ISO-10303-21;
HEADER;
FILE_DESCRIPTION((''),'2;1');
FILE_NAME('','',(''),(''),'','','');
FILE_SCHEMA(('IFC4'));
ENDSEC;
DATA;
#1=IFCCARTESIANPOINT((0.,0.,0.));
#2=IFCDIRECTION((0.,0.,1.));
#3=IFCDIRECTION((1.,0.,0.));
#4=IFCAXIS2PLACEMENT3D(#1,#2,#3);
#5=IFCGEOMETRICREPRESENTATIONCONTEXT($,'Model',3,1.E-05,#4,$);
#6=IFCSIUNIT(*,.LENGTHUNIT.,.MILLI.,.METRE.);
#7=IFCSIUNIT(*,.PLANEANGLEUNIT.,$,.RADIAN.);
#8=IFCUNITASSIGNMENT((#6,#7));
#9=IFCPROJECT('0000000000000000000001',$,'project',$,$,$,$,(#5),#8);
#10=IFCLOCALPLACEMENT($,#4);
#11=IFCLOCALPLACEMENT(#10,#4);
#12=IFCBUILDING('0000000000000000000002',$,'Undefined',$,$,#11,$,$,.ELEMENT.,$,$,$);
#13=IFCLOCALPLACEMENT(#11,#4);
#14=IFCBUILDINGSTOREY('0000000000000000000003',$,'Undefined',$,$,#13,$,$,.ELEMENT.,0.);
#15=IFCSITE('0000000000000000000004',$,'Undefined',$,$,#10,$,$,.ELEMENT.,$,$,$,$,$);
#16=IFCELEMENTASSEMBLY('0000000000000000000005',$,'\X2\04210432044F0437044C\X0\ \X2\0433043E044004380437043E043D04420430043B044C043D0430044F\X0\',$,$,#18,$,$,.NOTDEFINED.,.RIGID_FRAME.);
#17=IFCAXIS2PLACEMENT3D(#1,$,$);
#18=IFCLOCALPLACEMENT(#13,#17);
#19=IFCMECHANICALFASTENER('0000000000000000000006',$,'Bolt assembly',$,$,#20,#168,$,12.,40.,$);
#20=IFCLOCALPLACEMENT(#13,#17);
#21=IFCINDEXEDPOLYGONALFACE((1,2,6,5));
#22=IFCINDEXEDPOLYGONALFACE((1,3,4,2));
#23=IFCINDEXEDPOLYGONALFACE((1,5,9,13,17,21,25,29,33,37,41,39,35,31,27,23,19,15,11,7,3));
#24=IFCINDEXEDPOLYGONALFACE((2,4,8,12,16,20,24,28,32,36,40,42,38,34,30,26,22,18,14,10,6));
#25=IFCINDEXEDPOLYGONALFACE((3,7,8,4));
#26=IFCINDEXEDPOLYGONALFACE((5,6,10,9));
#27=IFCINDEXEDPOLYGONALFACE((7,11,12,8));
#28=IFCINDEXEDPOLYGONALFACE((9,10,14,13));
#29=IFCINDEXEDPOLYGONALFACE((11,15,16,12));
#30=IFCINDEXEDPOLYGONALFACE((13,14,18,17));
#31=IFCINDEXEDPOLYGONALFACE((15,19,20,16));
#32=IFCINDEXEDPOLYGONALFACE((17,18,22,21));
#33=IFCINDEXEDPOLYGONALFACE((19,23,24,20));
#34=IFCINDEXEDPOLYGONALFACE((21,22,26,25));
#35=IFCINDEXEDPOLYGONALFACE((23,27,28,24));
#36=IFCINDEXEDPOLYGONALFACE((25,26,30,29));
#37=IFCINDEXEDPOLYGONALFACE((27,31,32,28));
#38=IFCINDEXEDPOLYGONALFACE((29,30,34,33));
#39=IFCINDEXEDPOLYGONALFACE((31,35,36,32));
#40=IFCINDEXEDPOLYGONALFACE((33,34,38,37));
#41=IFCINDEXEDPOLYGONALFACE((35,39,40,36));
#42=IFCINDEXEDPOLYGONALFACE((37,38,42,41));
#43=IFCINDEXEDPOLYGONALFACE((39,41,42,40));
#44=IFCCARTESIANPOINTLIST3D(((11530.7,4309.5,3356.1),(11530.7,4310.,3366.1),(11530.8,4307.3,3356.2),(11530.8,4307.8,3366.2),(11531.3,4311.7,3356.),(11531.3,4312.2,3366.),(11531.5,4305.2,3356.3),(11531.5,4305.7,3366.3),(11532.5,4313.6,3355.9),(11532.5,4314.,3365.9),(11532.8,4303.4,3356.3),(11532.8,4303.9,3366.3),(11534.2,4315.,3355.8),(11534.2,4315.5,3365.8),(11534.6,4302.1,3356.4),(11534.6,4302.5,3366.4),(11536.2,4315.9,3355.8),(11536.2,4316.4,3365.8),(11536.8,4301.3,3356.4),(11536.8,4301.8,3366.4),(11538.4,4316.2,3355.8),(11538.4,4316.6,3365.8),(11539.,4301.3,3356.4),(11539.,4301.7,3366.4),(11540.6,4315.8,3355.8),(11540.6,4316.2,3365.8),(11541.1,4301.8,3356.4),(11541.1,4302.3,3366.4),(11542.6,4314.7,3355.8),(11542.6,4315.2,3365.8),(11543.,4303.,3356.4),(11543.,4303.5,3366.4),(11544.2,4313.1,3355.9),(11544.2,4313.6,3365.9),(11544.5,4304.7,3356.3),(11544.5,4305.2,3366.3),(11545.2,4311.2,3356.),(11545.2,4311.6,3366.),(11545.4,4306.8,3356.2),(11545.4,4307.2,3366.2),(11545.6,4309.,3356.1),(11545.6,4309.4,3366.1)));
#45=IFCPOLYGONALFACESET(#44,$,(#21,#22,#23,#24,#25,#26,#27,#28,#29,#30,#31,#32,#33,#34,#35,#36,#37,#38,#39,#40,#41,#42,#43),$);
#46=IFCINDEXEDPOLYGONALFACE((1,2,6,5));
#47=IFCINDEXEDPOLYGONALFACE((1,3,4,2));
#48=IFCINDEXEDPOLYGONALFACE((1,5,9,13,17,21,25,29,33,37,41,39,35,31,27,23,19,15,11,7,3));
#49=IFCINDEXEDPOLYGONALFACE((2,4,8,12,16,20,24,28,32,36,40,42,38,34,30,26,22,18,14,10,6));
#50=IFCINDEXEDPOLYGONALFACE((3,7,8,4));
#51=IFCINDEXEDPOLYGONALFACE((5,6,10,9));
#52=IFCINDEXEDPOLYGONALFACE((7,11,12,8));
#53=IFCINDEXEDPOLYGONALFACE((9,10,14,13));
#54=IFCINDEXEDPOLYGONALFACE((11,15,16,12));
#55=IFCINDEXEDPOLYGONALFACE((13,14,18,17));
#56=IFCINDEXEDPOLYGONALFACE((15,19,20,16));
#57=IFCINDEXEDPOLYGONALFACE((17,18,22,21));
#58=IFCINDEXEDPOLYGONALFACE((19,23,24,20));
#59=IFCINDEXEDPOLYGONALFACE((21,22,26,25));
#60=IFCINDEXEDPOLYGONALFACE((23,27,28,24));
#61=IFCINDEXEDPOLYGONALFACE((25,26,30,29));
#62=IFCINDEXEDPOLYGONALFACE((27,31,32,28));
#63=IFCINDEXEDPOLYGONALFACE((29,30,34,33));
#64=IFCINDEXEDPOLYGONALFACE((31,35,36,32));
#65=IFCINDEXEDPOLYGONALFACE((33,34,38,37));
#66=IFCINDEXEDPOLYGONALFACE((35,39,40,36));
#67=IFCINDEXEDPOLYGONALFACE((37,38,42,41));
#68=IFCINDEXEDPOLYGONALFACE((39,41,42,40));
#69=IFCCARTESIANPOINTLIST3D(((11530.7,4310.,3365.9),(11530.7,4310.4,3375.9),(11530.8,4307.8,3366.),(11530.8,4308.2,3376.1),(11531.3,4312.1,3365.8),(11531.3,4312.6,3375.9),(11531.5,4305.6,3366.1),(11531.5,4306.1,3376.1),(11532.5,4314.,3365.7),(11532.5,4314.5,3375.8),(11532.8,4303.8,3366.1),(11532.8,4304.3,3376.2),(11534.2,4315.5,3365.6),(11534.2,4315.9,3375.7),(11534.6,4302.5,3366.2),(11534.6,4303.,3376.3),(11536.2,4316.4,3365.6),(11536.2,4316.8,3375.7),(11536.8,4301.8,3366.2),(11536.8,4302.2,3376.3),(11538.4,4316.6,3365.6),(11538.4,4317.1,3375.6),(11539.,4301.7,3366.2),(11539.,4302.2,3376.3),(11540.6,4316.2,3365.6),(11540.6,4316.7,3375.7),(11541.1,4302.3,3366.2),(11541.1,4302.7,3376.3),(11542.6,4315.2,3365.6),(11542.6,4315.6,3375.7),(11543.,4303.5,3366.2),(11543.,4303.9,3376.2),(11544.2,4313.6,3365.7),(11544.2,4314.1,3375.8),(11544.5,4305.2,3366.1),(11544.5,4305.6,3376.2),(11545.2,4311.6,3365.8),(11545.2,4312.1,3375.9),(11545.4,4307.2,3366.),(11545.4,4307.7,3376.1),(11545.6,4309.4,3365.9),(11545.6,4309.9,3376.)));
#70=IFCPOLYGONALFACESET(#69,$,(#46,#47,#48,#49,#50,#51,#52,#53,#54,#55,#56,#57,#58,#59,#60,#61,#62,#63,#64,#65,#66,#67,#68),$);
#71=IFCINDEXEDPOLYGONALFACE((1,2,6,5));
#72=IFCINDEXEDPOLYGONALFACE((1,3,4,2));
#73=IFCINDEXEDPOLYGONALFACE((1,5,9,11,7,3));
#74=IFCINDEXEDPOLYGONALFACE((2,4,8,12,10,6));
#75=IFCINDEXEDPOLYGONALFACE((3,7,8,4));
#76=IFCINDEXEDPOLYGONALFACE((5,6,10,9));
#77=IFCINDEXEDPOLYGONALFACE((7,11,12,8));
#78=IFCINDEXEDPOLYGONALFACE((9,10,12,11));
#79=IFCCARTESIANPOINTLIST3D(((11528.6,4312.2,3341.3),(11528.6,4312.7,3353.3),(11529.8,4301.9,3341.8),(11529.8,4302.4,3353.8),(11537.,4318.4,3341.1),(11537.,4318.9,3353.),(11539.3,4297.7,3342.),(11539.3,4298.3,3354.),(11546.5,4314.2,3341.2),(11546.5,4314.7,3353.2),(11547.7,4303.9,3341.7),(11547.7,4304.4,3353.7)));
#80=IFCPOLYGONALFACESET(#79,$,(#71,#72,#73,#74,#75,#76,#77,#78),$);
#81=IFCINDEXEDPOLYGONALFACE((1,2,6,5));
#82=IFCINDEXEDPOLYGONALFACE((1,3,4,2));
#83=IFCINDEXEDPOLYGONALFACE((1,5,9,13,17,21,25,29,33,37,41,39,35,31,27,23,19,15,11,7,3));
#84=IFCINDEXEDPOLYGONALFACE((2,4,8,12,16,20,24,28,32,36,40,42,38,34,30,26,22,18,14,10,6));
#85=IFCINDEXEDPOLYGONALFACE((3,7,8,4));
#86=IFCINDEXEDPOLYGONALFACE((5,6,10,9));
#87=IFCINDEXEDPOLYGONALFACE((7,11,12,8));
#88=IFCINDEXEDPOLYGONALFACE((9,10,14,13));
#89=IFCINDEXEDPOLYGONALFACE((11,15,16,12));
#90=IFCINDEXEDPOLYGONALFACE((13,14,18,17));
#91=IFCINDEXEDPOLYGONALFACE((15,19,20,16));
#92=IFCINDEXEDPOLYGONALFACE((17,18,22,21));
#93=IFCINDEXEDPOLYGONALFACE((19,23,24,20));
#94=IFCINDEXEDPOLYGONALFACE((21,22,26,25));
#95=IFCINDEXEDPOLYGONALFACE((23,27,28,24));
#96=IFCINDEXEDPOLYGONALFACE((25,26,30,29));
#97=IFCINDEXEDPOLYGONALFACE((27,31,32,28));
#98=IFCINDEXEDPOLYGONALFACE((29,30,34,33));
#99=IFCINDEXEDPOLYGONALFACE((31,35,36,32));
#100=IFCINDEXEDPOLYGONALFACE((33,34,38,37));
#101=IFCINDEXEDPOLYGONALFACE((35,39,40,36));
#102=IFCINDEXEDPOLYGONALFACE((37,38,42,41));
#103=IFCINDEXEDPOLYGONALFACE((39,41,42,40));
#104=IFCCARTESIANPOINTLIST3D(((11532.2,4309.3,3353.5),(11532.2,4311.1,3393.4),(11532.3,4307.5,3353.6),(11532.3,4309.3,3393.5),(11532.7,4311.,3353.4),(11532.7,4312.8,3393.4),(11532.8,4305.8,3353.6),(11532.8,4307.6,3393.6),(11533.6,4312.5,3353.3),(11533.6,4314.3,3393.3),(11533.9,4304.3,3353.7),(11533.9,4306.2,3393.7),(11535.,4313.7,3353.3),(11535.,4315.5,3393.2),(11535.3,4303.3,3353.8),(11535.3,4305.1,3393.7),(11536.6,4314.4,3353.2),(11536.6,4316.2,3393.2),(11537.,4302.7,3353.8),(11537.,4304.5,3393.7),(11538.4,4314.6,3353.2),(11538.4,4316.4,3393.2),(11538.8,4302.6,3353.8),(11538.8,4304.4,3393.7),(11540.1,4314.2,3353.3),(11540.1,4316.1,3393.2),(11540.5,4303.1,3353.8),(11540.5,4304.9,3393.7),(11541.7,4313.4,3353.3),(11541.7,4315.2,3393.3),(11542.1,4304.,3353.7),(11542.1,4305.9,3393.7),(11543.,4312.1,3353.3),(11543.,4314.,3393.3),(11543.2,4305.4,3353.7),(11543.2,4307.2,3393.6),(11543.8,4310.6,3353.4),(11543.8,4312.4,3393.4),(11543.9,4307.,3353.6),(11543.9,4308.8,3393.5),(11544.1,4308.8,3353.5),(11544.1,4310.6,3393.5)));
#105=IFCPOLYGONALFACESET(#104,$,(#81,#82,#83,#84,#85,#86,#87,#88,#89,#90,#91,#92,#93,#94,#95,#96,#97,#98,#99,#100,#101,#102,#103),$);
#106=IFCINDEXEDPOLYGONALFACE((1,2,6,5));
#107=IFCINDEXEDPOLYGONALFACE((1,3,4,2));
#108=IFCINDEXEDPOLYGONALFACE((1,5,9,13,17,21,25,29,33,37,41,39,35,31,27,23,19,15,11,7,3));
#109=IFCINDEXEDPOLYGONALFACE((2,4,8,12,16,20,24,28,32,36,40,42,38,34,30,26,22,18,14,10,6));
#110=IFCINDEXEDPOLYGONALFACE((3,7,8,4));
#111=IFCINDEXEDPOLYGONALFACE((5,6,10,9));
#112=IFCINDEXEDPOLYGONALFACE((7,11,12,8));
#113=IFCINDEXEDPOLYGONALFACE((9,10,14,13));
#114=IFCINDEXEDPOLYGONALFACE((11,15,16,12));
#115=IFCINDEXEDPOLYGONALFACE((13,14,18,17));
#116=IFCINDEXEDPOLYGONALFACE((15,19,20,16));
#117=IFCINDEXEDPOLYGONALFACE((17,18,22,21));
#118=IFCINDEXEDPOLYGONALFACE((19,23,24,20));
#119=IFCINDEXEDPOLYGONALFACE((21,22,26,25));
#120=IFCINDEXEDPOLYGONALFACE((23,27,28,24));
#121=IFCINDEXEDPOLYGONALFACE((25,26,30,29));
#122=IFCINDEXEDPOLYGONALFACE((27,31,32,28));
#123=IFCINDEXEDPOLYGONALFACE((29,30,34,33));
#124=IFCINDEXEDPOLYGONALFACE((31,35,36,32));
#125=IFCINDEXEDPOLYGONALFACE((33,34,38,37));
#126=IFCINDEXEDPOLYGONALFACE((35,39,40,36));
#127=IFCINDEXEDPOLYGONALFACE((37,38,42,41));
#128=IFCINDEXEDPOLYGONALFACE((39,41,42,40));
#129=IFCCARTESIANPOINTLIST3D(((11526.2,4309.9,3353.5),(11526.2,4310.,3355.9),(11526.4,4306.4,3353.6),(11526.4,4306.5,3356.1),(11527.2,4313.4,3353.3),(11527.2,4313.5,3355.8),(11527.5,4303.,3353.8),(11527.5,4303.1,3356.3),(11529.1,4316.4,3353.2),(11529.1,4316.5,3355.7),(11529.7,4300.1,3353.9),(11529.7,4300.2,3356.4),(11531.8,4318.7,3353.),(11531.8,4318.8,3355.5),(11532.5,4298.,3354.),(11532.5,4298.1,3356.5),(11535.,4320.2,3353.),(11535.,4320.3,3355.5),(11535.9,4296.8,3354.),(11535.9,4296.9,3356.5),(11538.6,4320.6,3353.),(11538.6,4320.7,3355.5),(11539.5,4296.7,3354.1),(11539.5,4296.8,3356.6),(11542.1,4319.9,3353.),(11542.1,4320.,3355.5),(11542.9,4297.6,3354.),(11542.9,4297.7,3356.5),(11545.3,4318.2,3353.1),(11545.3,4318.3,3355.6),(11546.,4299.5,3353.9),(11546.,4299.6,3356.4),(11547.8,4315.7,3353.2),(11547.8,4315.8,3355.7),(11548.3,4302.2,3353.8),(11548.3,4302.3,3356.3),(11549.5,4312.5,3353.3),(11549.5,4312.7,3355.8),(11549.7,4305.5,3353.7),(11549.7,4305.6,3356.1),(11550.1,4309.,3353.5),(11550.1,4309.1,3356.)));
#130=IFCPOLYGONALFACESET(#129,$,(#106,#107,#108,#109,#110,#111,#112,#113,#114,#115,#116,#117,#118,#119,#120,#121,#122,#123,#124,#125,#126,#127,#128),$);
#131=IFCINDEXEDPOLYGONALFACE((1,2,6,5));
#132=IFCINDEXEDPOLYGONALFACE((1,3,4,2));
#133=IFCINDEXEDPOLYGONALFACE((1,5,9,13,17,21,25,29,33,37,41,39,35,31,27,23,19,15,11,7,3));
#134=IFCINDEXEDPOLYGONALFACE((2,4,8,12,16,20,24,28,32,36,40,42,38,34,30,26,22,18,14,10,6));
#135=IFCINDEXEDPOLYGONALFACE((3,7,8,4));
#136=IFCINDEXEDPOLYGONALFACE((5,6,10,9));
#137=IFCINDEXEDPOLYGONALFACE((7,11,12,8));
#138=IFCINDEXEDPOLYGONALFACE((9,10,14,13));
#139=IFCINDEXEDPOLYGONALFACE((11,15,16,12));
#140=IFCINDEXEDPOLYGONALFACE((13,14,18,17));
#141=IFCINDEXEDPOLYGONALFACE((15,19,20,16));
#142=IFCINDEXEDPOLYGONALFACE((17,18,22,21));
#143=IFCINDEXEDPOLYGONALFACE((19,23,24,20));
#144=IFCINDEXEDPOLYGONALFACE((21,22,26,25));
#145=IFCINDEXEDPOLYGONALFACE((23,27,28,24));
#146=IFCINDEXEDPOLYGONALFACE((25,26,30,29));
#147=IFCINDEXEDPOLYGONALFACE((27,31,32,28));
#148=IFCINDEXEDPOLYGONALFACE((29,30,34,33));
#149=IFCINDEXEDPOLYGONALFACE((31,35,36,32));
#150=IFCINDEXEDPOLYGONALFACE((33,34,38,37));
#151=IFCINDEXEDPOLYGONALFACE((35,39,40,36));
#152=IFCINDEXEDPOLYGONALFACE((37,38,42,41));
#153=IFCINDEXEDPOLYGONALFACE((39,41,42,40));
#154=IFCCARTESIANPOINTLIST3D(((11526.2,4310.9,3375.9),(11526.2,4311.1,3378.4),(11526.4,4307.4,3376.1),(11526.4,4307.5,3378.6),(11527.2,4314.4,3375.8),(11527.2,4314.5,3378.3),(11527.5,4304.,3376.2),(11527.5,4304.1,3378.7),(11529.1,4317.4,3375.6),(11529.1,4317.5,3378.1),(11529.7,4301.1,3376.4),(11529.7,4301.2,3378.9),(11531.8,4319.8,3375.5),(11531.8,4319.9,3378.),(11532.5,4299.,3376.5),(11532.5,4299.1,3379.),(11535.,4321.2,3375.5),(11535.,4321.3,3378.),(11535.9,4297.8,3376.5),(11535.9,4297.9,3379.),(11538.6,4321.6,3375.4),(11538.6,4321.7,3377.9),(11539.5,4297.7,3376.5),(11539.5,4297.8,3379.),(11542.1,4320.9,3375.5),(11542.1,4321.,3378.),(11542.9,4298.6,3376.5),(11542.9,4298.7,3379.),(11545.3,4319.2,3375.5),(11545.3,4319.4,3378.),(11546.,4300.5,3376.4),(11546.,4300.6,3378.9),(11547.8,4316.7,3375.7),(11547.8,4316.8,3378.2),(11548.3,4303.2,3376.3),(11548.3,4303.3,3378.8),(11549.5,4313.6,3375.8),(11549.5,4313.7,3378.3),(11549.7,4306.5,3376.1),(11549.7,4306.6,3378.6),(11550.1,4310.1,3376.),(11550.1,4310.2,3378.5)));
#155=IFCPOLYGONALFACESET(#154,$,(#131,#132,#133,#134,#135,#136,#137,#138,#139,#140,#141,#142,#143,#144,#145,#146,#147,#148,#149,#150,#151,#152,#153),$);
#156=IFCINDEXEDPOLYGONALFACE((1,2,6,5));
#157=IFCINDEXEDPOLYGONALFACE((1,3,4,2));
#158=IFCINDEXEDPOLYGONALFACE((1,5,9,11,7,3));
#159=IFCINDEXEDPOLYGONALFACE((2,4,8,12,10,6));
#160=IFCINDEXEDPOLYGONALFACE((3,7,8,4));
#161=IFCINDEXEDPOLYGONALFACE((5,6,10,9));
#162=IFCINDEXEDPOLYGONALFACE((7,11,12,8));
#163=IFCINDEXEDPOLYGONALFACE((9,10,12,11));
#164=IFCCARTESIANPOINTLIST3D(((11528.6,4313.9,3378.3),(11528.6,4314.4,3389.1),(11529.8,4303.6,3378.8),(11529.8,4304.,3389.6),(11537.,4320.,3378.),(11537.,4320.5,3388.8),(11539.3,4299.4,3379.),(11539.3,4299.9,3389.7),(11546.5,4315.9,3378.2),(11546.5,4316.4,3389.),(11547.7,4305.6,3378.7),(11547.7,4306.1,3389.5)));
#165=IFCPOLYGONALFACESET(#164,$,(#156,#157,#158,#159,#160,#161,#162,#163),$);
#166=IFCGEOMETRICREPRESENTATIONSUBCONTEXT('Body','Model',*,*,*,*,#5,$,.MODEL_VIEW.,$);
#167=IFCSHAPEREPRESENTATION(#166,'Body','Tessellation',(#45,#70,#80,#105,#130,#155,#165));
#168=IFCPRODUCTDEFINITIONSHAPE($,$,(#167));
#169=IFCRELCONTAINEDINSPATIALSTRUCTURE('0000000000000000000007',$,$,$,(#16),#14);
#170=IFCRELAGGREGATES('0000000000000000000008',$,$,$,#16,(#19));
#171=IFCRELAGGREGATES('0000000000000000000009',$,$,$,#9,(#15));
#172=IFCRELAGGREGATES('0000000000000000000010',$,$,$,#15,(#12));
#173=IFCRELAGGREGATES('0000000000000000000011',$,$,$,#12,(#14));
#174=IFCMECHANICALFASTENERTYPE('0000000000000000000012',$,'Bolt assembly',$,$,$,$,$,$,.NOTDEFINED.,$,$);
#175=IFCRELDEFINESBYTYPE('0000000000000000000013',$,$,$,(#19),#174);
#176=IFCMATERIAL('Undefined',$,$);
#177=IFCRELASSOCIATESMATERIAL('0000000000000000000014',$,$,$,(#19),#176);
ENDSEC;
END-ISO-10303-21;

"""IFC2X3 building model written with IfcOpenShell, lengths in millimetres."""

from ifc_helpers import new_model, si_unit, frame, origin_with_axes, origin_2d_with_axis, place, context, subcontext, project, spatial, polyline, circle, outline, extrude, source, transform, mapped, material, type_object, element, aggregate, save


model = new_model("IFC2X3")

# Units and contexts
model_context = context("Model", 3, precision=1e-05, world=origin_with_axes())
body_context = subcontext(model_context, "Body", "Model", "MODEL_VIEW")
ifc_project = project(units=[si_unit("LENGTHUNIT", "METRE", prefix="MILLI"), si_unit("PLANEANGLEUNIT", "RADIAN")], contexts=[model_context])

# Site, building, storey
site_placement = place(None, origin_with_axes())
site = spatial("IfcSite", under=ifc_project, at=site_placement, Name="Undefined", CompositionType="ELEMENT")
building_placement = place(site_placement, origin_with_axes())
building = spatial("IfcBuilding", under=site, at=building_placement, Name="Undefined", CompositionType="ELEMENT")
storey_placement = place(building_placement, origin_with_axes())
storey = spatial("IfcBuildingStorey", under=building, at=storey_placement, Name="Undefined", CompositionType="ELEMENT", Elevation=0.0)

# Element assembly
assembly_1_placement = place(storey_placement, origin_with_axes())
assembly_1 = element("IfcElementAssembly", 1, at=assembly_1_placement, inside=storey, Name="Связь горизонтальная", AssemblyPlace="NOTDEFINED", PredefinedType="RIGID_FRAME")

# Mechanical fastener
ifc_material_1 = material(Name="Undefined")
mechanical_fastener_type = type_object("IfcMechanicalFastenerType", Name="Bolt assembly")
shared_shape_1 = source(origin_with_axes(), body_context, "Body", "SweptSolid", [
    extrude(circle(Radius=7.5, at=origin_2d_with_axis()), frame((0.0, 0.1, 0.0), z_axis=(0.0, 1.0, 0.0), x_axis=(1.0, 0.0, 0.0)), (0.0, 0.0, 1.0), 10.0),
    extrude(circle(Radius=7.5, at=origin_2d_with_axis()), frame((0.0, 9.9, 0.0), z_axis=(0.0, 1.0, 0.0), x_axis=(1.0, 0.0, 0.0)), (0.0, 0.0, 1.0), 10.1),
    extrude(outline(polyline([(10.4, 0.0), (5.2, 9.0), (-5.2, 9.0), (-10.4, 0.0), (-5.2, -9.0), (5.2, -9.0), (10.4, 0.0)])), frame((0.0, -14.5, 0.0), z_axis=(0.0, 1.0, 0.0), x_axis=(1.0, 0.0, 0.0)), (0.0, 0.0, 1.0), 12.0),
    extrude(circle(Radius=6.0, at=origin_2d_with_axis()), frame((0.0, -2.5, 0.0), z_axis=(0.0, 1.0, 0.0), x_axis=(1.0, 0.0, 0.0)), (0.0, 0.0, 1.0), 40.0),
    extrude(circle(Radius=12.0, at=origin_2d_with_axis()), frame((0.0, -2.5, 0.0), z_axis=(0.0, 1.0, 0.0), x_axis=(1.0, 0.0, 0.0)), (0.0, 0.0, 1.0), 2.5),
    extrude(circle(Radius=12.0, at=origin_2d_with_axis()), frame((0.0, 20.0, 0.0), z_axis=(0.0, 1.0, 0.0), x_axis=(1.0, 0.0, 0.0)), (0.0, 0.0, 1.0), 2.5),
    extrude(outline(polyline([(10.4, 0.0), (5.2, 9.0), (-5.2, 9.0), (-10.4, 0.0), (-5.2, -9.0), (5.2, -9.0), (10.4, 0.0)])), frame((0.0, 22.5, 0.0), z_axis=(0.0, 1.0, 0.0), x_axis=(1.0, 0.0, 0.0)), (0.0, 0.0, 1.0), 10.8),
])
mechanical_fastener_1_placement = place(assembly_1_placement, frame((11538.1, 4308.7, 3356.0), z_axis=(0.593795, -0.803786, 0.036536), x_axis=(0.804616, 0.593183, -0.026963)))
mechanical_fastener_1 = element("IfcMechanicalFastener", 2, at=mechanical_fastener_1_placement, type_object=mechanical_fastener_type, material=ifc_material_1, Name="Bolt assembly", NominalDiameter=12.0, NominalLength=40.0, context=body_context, shape_type="MappedRepresentation", body=[
    mapped(shared_shape_1, transform((0.0, 0.0, 0.0))),
])
aggregate(assembly_1, [mechanical_fastener_1])

save(model, "model.ifc")
